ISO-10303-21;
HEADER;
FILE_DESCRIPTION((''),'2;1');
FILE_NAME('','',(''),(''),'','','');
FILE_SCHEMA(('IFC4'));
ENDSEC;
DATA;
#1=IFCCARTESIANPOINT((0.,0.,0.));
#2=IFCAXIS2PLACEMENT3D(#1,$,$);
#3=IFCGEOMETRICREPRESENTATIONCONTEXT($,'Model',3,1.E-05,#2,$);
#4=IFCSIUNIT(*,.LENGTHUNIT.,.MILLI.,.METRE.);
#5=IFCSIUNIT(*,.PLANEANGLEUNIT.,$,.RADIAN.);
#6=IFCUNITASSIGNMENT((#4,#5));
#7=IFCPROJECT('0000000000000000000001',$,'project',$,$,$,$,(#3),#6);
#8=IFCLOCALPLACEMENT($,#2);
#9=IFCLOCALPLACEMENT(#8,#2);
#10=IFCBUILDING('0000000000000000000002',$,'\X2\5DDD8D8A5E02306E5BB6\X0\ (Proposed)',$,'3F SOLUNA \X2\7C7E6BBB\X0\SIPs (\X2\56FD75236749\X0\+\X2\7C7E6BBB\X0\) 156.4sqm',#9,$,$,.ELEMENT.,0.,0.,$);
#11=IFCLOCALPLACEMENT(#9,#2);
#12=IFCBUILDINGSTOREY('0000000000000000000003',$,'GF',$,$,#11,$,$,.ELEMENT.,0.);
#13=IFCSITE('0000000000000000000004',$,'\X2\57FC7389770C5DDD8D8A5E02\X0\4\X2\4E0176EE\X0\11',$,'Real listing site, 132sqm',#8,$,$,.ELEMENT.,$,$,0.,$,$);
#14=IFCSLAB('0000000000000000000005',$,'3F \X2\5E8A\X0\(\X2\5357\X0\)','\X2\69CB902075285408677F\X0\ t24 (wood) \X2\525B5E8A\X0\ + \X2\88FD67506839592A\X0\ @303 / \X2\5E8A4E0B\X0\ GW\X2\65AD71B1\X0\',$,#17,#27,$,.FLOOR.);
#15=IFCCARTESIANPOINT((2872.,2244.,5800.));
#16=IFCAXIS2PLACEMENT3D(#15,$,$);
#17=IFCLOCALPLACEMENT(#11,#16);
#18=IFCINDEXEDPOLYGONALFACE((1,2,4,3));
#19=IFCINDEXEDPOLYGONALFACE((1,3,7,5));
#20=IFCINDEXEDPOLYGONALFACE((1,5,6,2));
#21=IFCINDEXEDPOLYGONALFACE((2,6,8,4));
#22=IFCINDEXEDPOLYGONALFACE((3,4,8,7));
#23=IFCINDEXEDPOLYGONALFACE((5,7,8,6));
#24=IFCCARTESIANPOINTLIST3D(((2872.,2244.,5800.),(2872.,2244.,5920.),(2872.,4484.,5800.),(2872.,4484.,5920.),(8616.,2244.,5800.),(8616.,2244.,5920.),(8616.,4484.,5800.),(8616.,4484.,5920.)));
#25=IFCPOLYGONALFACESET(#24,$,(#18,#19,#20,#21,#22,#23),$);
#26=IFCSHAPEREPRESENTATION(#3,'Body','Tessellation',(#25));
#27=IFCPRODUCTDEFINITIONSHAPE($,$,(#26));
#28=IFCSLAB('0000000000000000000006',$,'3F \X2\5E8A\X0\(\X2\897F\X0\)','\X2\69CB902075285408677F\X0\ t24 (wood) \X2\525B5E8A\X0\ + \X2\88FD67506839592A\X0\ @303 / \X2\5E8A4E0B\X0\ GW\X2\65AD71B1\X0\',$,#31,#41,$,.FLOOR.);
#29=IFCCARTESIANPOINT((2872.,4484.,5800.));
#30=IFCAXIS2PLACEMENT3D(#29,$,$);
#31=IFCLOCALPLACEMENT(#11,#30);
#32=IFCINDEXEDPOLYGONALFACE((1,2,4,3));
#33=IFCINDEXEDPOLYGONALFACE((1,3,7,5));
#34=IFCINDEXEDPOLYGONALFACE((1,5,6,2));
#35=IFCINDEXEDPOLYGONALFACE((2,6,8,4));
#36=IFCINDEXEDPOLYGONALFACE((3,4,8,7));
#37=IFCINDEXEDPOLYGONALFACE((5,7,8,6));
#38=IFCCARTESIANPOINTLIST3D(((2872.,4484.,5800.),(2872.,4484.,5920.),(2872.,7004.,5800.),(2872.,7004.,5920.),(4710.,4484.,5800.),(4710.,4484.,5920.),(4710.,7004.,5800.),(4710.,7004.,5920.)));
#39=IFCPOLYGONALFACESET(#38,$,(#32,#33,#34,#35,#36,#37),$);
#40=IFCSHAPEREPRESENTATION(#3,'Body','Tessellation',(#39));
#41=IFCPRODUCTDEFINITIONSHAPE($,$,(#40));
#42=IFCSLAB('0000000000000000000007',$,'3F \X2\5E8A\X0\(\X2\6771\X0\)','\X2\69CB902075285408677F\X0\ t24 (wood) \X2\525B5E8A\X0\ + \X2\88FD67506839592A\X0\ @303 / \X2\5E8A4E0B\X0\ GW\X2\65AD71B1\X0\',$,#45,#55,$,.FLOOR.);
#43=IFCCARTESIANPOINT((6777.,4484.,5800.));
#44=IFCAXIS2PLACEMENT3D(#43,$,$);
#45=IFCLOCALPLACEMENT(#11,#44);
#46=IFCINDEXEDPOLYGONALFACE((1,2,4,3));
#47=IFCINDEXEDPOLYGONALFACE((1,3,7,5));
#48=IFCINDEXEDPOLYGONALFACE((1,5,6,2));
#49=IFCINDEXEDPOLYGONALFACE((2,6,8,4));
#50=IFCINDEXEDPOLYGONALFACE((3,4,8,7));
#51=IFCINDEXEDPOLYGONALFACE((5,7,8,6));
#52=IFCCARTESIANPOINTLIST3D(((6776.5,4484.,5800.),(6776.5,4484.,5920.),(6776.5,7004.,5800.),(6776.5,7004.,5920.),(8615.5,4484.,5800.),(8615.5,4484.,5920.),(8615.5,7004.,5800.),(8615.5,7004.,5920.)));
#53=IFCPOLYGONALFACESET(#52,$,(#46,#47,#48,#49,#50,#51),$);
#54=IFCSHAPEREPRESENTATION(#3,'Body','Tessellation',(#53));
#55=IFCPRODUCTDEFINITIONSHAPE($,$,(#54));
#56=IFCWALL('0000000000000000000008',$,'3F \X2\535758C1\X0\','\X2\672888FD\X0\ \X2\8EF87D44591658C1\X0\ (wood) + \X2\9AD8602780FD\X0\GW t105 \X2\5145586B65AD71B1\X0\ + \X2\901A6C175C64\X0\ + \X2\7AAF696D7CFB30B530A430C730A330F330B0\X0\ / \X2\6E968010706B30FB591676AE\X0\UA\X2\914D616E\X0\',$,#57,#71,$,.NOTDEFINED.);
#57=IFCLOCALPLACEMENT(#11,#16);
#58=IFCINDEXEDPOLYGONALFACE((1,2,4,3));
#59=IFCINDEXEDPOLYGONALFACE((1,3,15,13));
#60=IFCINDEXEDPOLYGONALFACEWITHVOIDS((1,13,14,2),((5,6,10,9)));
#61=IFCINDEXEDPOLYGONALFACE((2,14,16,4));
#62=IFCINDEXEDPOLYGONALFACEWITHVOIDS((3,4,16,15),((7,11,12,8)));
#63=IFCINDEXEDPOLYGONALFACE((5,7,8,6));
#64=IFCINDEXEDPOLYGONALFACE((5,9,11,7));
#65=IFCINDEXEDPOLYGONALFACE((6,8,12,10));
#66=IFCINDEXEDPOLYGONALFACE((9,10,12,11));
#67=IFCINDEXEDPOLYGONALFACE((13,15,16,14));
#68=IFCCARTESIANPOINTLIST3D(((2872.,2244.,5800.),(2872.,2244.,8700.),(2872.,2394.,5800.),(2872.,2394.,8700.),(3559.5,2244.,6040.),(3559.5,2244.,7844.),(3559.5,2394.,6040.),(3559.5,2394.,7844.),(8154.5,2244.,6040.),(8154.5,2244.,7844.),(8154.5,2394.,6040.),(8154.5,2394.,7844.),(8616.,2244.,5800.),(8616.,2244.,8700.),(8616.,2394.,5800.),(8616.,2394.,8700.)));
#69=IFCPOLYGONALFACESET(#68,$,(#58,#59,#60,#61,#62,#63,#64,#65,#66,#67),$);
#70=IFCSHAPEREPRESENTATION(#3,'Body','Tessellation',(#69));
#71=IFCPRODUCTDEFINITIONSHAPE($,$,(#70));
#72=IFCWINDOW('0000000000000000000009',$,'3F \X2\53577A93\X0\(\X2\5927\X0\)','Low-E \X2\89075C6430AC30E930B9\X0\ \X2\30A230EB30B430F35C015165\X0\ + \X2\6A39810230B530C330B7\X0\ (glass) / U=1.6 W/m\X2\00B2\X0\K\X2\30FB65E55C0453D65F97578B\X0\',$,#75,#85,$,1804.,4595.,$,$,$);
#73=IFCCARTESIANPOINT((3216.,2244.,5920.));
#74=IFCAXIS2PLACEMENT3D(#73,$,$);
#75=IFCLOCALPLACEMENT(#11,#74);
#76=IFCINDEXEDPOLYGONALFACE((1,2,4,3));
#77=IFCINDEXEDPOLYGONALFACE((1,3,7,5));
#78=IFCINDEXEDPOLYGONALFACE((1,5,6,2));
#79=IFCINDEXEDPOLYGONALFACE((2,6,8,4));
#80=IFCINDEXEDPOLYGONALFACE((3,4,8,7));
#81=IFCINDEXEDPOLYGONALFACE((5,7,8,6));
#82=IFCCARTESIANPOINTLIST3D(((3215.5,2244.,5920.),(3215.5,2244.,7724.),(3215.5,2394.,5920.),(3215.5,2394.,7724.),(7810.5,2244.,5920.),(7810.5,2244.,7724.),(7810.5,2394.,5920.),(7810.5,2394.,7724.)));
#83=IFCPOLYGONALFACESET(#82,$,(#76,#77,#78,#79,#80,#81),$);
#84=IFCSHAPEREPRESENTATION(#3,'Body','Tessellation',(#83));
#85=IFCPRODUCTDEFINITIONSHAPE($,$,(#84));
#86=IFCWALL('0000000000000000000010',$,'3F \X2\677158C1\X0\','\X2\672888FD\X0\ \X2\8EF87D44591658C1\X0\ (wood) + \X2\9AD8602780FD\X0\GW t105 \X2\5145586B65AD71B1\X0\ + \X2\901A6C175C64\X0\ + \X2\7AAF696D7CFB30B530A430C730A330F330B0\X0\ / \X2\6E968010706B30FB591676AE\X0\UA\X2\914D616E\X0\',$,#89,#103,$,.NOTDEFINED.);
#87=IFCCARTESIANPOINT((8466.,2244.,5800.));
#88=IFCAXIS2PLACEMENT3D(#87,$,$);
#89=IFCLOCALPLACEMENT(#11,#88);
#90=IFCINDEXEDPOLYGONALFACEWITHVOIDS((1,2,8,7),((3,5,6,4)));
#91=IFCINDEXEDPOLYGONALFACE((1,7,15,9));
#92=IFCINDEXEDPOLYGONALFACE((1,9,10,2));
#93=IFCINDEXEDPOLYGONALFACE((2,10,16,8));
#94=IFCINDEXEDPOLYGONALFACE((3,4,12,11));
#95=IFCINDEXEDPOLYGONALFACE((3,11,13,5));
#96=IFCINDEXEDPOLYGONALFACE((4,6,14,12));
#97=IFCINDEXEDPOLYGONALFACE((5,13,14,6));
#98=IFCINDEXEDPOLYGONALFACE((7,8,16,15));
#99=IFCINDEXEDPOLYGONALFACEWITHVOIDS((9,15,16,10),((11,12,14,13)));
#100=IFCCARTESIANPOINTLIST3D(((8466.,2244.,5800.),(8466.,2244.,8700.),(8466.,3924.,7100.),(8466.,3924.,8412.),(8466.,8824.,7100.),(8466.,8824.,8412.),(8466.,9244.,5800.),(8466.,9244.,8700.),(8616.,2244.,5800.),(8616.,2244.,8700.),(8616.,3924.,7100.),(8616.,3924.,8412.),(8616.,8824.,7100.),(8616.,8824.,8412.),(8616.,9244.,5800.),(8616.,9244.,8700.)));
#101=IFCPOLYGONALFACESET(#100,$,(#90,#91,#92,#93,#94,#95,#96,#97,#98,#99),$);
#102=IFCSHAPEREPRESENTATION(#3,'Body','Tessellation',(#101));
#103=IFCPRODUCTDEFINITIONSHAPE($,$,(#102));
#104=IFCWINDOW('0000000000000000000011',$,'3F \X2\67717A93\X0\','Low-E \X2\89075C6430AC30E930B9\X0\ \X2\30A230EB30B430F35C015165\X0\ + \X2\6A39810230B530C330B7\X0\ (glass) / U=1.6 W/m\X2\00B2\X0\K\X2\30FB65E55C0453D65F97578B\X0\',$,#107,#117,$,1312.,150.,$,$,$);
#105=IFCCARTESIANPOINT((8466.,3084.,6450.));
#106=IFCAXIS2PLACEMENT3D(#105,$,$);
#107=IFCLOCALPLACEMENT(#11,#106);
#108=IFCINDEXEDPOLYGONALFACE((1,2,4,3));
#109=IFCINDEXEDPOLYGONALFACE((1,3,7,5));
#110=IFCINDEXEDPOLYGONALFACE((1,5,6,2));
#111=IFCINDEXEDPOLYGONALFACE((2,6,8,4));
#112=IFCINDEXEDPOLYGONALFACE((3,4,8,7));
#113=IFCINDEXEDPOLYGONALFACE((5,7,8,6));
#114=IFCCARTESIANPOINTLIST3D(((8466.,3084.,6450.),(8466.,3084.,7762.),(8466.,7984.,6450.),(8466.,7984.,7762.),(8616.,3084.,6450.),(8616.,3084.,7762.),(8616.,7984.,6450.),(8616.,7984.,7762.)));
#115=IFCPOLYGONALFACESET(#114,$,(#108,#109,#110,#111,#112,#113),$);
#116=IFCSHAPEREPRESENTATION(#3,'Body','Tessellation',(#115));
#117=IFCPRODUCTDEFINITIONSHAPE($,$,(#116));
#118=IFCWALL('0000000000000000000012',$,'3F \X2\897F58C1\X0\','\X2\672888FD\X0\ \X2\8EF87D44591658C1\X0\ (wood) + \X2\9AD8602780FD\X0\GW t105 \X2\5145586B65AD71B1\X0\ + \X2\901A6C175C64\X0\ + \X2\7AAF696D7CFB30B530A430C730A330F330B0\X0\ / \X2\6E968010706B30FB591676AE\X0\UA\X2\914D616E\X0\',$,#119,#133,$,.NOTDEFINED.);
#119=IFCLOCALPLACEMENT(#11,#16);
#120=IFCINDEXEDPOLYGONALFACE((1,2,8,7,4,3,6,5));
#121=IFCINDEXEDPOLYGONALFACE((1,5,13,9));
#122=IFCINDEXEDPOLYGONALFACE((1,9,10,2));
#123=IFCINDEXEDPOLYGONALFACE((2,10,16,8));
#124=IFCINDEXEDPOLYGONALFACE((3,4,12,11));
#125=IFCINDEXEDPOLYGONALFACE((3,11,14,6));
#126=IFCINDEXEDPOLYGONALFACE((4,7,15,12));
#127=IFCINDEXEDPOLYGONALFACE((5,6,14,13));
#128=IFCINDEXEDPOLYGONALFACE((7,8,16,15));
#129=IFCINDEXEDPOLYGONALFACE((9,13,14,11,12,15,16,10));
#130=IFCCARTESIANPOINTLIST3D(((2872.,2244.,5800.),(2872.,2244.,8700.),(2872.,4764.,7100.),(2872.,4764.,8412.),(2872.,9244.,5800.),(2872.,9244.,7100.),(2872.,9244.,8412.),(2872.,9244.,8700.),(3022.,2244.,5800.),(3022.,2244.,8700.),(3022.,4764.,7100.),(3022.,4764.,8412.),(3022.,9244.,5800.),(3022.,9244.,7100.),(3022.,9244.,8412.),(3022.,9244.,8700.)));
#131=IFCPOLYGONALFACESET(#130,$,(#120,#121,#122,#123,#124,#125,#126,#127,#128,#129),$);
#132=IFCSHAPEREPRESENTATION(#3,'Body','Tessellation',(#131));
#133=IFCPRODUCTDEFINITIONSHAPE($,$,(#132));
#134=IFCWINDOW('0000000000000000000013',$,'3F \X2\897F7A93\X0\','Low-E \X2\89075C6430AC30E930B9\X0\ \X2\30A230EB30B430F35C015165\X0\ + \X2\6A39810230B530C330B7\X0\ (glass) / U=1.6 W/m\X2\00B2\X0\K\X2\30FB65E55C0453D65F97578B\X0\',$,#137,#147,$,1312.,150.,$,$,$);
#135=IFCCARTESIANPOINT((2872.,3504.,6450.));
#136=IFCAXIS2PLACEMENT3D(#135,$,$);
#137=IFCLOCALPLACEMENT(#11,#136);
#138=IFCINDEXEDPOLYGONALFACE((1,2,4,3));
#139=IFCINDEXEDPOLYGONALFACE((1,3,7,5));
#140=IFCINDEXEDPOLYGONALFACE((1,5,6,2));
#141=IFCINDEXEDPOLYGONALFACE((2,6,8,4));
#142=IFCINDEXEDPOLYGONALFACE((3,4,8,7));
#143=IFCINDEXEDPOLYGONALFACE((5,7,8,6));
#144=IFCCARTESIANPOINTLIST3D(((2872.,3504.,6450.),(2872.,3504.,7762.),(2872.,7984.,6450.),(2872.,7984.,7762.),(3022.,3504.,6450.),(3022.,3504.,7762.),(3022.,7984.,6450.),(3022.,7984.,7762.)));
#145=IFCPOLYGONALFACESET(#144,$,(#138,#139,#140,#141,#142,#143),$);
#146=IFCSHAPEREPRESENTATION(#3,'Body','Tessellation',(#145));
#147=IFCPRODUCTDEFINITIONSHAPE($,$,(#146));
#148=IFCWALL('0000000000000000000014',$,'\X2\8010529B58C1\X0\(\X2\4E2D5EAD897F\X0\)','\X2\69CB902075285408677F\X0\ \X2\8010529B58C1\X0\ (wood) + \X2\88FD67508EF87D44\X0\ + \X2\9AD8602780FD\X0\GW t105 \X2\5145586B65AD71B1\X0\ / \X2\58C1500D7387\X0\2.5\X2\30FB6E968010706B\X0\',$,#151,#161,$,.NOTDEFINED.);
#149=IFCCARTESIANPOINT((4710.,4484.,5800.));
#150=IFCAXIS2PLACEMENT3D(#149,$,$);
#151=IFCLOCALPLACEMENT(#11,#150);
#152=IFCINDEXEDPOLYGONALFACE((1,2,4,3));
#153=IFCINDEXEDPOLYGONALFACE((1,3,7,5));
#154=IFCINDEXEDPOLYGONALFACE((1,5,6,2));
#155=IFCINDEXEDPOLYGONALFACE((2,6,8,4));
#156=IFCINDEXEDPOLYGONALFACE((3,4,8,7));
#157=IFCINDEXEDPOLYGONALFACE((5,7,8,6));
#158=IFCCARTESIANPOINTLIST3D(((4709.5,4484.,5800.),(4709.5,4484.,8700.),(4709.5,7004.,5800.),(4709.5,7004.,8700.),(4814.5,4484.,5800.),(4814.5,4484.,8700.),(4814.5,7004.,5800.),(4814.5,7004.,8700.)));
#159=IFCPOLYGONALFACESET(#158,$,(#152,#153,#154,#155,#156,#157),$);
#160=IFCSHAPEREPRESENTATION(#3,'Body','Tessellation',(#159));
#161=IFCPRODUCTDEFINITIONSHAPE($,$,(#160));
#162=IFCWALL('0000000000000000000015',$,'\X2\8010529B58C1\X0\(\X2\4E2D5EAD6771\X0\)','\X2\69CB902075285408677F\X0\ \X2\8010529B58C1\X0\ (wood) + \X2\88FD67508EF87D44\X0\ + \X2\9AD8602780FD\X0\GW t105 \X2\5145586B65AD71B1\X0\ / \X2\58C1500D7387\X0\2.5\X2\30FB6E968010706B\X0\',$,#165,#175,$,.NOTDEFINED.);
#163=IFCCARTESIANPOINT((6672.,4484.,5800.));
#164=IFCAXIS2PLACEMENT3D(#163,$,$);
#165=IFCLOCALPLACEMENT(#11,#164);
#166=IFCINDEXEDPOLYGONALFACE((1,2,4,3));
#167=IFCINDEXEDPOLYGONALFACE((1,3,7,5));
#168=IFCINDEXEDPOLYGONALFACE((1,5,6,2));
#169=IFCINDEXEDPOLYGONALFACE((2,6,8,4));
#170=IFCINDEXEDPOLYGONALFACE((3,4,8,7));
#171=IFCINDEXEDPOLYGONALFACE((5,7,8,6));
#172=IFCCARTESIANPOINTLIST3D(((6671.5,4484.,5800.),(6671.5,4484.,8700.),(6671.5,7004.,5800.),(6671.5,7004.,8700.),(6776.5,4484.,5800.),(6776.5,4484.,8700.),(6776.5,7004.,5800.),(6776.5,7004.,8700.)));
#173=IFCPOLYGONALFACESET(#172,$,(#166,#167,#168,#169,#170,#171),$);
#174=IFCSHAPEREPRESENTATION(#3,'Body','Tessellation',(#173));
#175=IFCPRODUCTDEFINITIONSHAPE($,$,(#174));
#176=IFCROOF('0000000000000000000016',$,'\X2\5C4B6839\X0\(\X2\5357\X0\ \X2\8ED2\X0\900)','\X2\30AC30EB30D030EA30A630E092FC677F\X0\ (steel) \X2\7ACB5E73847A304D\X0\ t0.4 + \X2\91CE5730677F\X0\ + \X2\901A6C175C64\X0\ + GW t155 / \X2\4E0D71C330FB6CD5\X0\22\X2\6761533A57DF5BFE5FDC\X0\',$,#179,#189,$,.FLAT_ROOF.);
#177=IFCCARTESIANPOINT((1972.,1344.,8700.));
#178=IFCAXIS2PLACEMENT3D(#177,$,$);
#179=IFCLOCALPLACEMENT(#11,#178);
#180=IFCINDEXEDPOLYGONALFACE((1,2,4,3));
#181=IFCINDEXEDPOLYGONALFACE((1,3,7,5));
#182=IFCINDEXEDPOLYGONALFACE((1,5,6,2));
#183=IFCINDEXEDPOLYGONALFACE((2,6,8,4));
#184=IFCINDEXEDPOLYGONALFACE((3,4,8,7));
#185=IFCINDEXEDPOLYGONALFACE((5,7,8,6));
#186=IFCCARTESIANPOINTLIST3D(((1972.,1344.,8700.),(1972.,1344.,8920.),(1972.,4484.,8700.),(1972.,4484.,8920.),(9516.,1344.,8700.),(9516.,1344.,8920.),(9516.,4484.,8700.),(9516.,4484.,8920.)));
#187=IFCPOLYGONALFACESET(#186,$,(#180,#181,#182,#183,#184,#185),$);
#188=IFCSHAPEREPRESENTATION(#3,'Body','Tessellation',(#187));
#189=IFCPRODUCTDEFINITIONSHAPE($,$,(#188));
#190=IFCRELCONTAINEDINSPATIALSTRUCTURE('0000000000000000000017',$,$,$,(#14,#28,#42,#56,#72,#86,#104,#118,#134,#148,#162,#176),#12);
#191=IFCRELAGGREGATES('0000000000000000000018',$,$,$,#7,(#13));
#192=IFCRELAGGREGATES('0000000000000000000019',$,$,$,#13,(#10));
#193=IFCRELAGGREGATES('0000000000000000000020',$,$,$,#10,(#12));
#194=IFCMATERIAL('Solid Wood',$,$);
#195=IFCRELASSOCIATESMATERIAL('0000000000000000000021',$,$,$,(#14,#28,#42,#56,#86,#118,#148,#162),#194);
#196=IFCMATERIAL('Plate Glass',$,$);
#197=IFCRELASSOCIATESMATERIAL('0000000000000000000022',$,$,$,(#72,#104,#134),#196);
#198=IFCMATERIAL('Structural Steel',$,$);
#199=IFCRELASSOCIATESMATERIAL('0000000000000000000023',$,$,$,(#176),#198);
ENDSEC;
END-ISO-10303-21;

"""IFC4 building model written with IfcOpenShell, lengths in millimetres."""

from ifc_helpers import new_model, si_unit, frame, frame_2d, origin, place, context, project, spatial, rectangle, extrude, material, element, fill, save


model = new_model("IFC4")

# Units and contexts
model_context = context("Model", 3, precision=1e-05, world=origin())
ifc_project = project(units=[si_unit("LENGTHUNIT", "METRE", prefix="MILLI"), si_unit("PLANEANGLEUNIT", "RADIAN")], contexts=[model_context])

# Site, building, storey
site_placement = place(None, origin())
site = spatial("IfcSite", under=ifc_project, at=site_placement, Name="埼玉県川越市4丁目11", ObjectType="Real listing site, 132sqm", CompositionType="ELEMENT", RefElevation=0.0)
building_placement = place(site_placement, origin())
building = spatial("IfcBuilding", under=site, at=building_placement, Name="川越市の家 (Proposed)", ObjectType="3F SOLUNA 籾殻SIPs (国産杉+籾殻) 156.4sqm", CompositionType="ELEMENT", ElevationOfRefHeight=0.0, ElevationOfTerrain=0.0)
storey_placement = place(building_placement, origin())
storey = spatial("IfcBuildingStorey", under=building, at=storey_placement, Name="GF", CompositionType="ELEMENT", Elevation=0.0)

# Slabs
ifc_material_1 = material(Name="Solid Wood")
slab_1_placement = place(storey_placement, frame((2872.0, 2244.0, 5800.0)))
element("IfcSlab", 1, at=slab_1_placement, inside=storey, material=ifc_material_1, Name="3F 床(南)", Description="構造用合板 t24 (wood) 剛床 + 製材根太 @303 / 床下 GW断熱", PredefinedType="FLOOR", context=model_context, shape_type="SweptSolid", body=[
    extrude(rectangle(XDim=5744.0, YDim=2240.0, at=frame_2d((2872.0, 1120.0))), frame((2872.0, 2244.0, 5800.0)), (0.0, 0.0, 1.0), 120.0),
])
slab_2_placement = place(storey_placement, frame((2872.0, 4484.0, 5800.0)))
element("IfcSlab", 2, at=slab_2_placement, inside=storey, material=ifc_material_1, Name="3F 床(西)", Description="構造用合板 t24 (wood) 剛床 + 製材根太 @303 / 床下 GW断熱", PredefinedType="FLOOR", context=model_context, shape_type="SweptSolid", body=[
    extrude(rectangle(XDim=1838.0, YDim=2520.0, at=frame_2d((919.0, 1260.0))), frame((2872.0, 4484.0, 5800.0)), (0.0, 0.0, 1.0), 120.0),
])
slab_3_placement = place(storey_placement, frame((6777.0, 4484.0, 5800.0)))
element("IfcSlab", 3, at=slab_3_placement, inside=storey, material=ifc_material_1, Name="3F 床(東)", Description="構造用合板 t24 (wood) 剛床 + 製材根太 @303 / 床下 GW断熱", PredefinedType="FLOOR", context=model_context, shape_type="SweptSolid", body=[
    extrude(rectangle(XDim=1839.0, YDim=2520.0, at=frame_2d((919.0, 1260.0))), frame((6777.0, 4484.0, 5800.0)), (0.0, 0.0, 1.0), 120.0),
])

# Walls, openings, windows
wall_1_placement = place(storey_placement, frame((2872.0, 2244.0, 5800.0)))
wall_1 = element("IfcWall", 4, at=wall_1_placement, inside=storey, material=ifc_material_1, Name="3F 南壁", Description="木製 軸組外壁 (wood) + 高性能GW t105 充填断熱 + 通気層 + 窯業系サイディング / 準耐火・外皮UA配慮", PredefinedType="NOTDEFINED", context=model_context, shape_type="SweptSolid", body=[
    extrude(rectangle(XDim=5744.0, YDim=150.0, at=frame_2d((2872.0, 75.0))), frame((2872.0, 2244.0, 5800.0)), (0.0, 0.0, 1.0), 2900.0),
])
opening_1_placement = place(storey_placement, frame((3216.0, 2244.0, 5920.0)))
opening_1 = element("IfcOpeningElement", 5, at=opening_1_placement, cuts=wall_1, PredefinedType="NOTDEFINED", context=model_context, shape_type="SweptSolid", body=[
    extrude(rectangle(XDim=4595.0, YDim=150.0, at=frame_2d((2297.0, 75.0))), frame((3216.0, 2244.0, 5920.0)), (0.0, 0.0, 1.0), 1804.0),
])
ifc_material_2 = material(Name="Plate Glass")
window_1_placement = place(storey_placement, frame((3216.0, 2244.0, 5920.0)))
window_1 = element("IfcWindow", 6, at=window_1_placement, inside=storey, material=ifc_material_2, Name="3F 南窓(大)", Description="Low-E 複層ガラス アルゴン封入 + 樹脂サッシ (glass) / U=1.6 W/m²K・日射取得型", OverallHeight=1804.0, OverallWidth=4595.0, context=model_context, shape_type="SweptSolid", body=[
    extrude(rectangle(XDim=4595.0, YDim=150.0, at=frame_2d((2297.0, 75.0))), frame((3216.0, 2244.0, 5920.0)), (0.0, 0.0, 1.0), 1804.0),
])
fill(opening_1, window_1)
wall_2_placement = place(storey_placement, frame((8466.0, 2244.0, 5800.0)))
wall_2 = element("IfcWall", 7, at=wall_2_placement, inside=storey, material=ifc_material_1, Name="3F 東壁", Description="木製 軸組外壁 (wood) + 高性能GW t105 充填断熱 + 通気層 + 窯業系サイディング / 準耐火・外皮UA配慮", PredefinedType="NOTDEFINED", context=model_context, shape_type="SweptSolid", body=[
    extrude(rectangle(XDim=150.0, YDim=7000.0, at=frame_2d((75.0, 3500.0))), frame((8466.0, 2244.0, 5800.0)), (0.0, 0.0, 1.0), 2900.0),
])
opening_2_placement = place(storey_placement, frame((8466.0, 3084.0, 6450.0)))
opening_2 = element("IfcOpeningElement", 8, at=opening_2_placement, cuts=wall_2, PredefinedType="NOTDEFINED", context=model_context, shape_type="SweptSolid", body=[
    extrude(rectangle(XDim=150.0, YDim=4900.0, at=frame_2d((75.0, 2450.0))), frame((8466.0, 3084.0, 6450.0)), (0.0, 0.0, 1.0), 1312.0),
])
window_2_placement = place(storey_placement, frame((8466.0, 3084.0, 6450.0)))
window_2 = element("IfcWindow", 9, at=window_2_placement, inside=storey, material=ifc_material_2, Name="3F 東窓", Description="Low-E 複層ガラス アルゴン封入 + 樹脂サッシ (glass) / U=1.6 W/m²K・日射取得型", OverallHeight=1312.0, OverallWidth=150.0, context=model_context, shape_type="SweptSolid", body=[
    extrude(rectangle(XDim=150.0, YDim=4900.0, at=frame_2d((75.0, 2450.0))), frame((8466.0, 3084.0, 6450.0)), (0.0, 0.0, 1.0), 1312.0),
])
fill(opening_2, window_2)
wall_3_placement = place(storey_placement, frame((2872.0, 2244.0, 5800.0)))
wall_3 = element("IfcWall", 10, at=wall_3_placement, inside=storey, material=ifc_material_1, Name="3F 西壁", Description="木製 軸組外壁 (wood) + 高性能GW t105 充填断熱 + 通気層 + 窯業系サイディング / 準耐火・外皮UA配慮", PredefinedType="NOTDEFINED", context=model_context, shape_type="SweptSolid", body=[
    extrude(rectangle(XDim=150.0, YDim=7000.0, at=frame_2d((75.0, 3500.0))), frame((2872.0, 2244.0, 5800.0)), (0.0, 0.0, 1.0), 2900.0),
])
opening_3_placement = place(storey_placement, frame((2872.0, 3504.0, 6450.0)))
opening_3 = element("IfcOpeningElement", 11, at=opening_3_placement, cuts=wall_3, PredefinedType="NOTDEFINED", context=model_context, shape_type="SweptSolid", body=[
    extrude(rectangle(XDim=150.0, YDim=4480.0, at=frame_2d((75.0, 2240.0))), frame((2872.0, 3504.0, 6450.0)), (0.0, 0.0, 1.0), 1312.0),
])
window_3_placement = place(storey_placement, frame((2872.0, 3504.0, 6450.0)))
window_3 = element("IfcWindow", 12, at=window_3_placement, inside=storey, material=ifc_material_2, Name="3F 西窓", Description="Low-E 複層ガラス アルゴン封入 + 樹脂サッシ (glass) / U=1.6 W/m²K・日射取得型", OverallHeight=1312.0, OverallWidth=150.0, context=model_context, shape_type="SweptSolid", body=[
    extrude(rectangle(XDim=150.0, YDim=4480.0, at=frame_2d((75.0, 2240.0))), frame((2872.0, 3504.0, 6450.0)), (0.0, 0.0, 1.0), 1312.0),
])
fill(opening_3, window_3)

# Walls
wall_4_placement = place(storey_placement, frame((4710.0, 4484.0, 5800.0)))
element("IfcWall", 13, at=wall_4_placement, inside=storey, material=ifc_material_1, Name="耐力壁(中庭西)", Description="構造用合板 耐力壁 (wood) + 製材軸組 + 高性能GW t105 充填断熱 / 壁倍率2.5・準耐火", PredefinedType="NOTDEFINED", context=model_context, shape_type="SweptSolid", body=[
    extrude(rectangle(XDim=105.0, YDim=2520.0, at=frame_2d((52.0, 1260.0))), frame((4710.0, 4484.0, 5800.0)), (0.0, 0.0, 1.0), 2900.0),
])
wall_5_placement = place(storey_placement, frame((6672.0, 4484.0, 5800.0)))
element("IfcWall", 14, at=wall_5_placement, inside=storey, material=ifc_material_1, Name="耐力壁(中庭東)", Description="構造用合板 耐力壁 (wood) + 製材軸組 + 高性能GW t105 充填断熱 / 壁倍率2.5・準耐火", PredefinedType="NOTDEFINED", context=model_context, shape_type="SweptSolid", body=[
    extrude(rectangle(XDim=105.0, YDim=2520.0, at=frame_2d((52.0, 1260.0))), frame((6672.0, 4484.0, 5800.0)), (0.0, 0.0, 1.0), 2900.0),
])

# Roof
ifc_material_3 = material(Name="Structural Steel")
roof_1_placement = place(storey_placement, frame((1972.0, 1344.0, 8700.0)))
element("IfcRoof", 15, at=roof_1_placement, inside=storey, material=ifc_material_3, Name="屋根(南 軒900)", Description="ガルバリウム鋼板 (steel) 立平葺き t0.4 + 野地板 + 通気層 + GW t155 / 不燃・法22条区域対応", PredefinedType="FLAT_ROOF", context=model_context, shape_type="SweptSolid", body=[
    extrude(rectangle(XDim=7544.0, YDim=3140.0, at=frame_2d((3772.0, 1570.0))), frame((1972.0, 1344.0, 8700.0)), (0.0, 0.0, 1.0), 220.0),
])

save(model, "model.ifc")
